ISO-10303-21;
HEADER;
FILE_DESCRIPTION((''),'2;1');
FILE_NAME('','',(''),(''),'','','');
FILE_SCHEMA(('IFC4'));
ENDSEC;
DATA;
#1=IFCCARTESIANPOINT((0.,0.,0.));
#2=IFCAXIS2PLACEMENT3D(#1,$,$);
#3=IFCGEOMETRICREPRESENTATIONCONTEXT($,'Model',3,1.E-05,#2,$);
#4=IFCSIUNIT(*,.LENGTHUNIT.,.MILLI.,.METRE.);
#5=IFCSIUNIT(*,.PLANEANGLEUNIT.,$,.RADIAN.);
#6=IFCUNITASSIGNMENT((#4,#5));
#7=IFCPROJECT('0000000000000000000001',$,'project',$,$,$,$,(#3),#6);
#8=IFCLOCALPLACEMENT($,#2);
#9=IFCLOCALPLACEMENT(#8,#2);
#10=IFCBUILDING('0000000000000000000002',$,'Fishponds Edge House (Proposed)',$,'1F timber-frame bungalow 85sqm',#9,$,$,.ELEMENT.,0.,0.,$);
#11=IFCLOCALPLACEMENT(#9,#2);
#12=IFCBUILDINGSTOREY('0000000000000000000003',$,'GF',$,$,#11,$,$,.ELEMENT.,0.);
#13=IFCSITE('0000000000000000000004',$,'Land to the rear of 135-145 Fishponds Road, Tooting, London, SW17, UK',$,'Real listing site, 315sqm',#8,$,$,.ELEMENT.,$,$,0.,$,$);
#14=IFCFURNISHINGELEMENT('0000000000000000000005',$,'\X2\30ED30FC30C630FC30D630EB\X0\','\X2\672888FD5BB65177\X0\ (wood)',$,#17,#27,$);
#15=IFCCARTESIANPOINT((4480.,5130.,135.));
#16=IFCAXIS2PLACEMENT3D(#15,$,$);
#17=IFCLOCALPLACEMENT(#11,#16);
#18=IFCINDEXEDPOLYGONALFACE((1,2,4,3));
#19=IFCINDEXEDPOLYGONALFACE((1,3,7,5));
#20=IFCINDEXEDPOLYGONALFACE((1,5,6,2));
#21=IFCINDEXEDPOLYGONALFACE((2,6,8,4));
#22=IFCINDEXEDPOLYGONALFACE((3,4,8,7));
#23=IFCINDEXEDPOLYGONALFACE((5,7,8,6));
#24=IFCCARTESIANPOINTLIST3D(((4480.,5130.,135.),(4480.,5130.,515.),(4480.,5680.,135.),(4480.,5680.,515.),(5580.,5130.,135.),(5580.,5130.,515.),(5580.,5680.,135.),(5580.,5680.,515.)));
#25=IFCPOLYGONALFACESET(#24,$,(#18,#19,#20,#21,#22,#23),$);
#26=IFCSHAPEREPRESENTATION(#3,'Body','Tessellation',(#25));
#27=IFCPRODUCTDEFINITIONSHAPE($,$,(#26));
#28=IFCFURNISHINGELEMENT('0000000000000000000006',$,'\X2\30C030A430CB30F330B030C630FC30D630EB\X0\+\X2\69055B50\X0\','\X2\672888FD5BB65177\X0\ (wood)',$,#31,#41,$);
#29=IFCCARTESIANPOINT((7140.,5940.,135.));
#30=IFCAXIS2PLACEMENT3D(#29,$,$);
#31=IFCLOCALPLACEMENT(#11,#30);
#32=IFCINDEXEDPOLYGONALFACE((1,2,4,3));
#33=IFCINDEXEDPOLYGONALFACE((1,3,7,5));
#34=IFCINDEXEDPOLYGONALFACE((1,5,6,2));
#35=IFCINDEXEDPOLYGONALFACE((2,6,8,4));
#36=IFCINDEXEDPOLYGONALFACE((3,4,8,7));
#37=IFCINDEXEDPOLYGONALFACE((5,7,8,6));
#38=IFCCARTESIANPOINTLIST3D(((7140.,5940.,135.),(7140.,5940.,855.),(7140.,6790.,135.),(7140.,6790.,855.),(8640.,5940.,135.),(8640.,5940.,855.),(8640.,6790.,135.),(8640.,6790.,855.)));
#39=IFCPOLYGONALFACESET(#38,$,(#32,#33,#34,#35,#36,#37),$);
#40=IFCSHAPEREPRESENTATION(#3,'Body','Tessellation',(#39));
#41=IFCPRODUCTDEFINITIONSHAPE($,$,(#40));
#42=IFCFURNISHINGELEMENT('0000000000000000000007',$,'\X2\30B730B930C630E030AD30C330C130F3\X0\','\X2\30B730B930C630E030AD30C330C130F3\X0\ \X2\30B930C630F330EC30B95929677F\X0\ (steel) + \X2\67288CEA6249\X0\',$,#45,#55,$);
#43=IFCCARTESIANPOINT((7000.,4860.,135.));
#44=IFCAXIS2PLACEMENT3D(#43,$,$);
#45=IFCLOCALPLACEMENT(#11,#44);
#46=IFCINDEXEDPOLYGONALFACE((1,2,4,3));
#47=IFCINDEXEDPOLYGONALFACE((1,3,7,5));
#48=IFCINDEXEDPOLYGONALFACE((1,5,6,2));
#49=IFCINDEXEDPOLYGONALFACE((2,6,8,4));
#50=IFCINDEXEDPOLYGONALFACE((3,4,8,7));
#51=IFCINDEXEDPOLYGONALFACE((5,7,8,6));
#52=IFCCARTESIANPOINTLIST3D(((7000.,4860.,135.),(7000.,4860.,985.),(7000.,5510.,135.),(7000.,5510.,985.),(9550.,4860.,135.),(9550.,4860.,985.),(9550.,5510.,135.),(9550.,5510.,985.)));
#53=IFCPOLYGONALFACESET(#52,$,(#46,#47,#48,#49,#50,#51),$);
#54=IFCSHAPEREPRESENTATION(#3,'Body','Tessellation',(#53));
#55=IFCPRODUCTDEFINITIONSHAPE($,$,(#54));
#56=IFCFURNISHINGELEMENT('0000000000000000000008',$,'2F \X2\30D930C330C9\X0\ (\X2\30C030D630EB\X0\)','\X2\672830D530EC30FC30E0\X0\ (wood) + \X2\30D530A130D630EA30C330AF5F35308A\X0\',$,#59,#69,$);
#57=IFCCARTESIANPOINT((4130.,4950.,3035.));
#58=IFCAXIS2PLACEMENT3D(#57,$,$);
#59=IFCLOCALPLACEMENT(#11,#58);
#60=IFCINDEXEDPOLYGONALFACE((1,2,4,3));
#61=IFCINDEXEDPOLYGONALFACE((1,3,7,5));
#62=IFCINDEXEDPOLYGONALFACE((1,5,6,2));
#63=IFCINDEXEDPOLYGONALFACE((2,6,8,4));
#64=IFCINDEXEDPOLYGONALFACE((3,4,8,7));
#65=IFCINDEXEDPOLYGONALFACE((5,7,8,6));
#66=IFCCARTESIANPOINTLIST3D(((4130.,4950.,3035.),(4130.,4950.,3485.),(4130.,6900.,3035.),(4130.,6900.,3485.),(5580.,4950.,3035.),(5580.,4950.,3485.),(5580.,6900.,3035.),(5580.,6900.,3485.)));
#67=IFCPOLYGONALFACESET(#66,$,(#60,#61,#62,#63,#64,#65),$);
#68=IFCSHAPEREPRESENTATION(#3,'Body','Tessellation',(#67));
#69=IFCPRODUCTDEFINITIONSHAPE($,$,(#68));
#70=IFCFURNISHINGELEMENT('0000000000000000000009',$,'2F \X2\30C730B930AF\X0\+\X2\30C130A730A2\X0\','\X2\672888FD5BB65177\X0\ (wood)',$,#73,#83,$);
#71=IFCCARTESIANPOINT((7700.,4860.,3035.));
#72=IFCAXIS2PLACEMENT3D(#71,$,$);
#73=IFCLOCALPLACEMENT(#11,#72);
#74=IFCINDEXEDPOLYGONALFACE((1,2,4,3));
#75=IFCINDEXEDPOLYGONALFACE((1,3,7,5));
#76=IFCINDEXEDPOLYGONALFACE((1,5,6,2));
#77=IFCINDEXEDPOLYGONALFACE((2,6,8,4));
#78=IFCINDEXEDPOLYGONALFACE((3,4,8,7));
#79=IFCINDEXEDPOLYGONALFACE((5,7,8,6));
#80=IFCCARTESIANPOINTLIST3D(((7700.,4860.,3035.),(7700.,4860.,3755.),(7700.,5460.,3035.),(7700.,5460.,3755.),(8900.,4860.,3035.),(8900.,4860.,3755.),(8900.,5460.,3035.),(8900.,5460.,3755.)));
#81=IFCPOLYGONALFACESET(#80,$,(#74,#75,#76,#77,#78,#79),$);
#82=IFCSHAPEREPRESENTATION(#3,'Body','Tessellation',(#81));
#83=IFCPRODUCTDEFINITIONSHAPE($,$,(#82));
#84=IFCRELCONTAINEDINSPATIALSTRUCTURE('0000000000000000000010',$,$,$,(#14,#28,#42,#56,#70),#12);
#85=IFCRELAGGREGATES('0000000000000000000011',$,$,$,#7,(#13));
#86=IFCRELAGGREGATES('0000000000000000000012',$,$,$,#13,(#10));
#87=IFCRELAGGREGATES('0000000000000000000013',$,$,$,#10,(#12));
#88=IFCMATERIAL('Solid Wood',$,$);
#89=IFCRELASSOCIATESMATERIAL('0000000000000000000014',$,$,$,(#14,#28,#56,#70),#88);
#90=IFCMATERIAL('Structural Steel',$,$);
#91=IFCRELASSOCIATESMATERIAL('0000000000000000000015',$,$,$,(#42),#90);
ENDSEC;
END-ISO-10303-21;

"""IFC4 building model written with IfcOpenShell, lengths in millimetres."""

from ifc_helpers import new_model, si_unit, frame, frame_2d, origin, place, context, project, spatial, rectangle, extrude, material, element, save


model = new_model("IFC4")

# Units and contexts
model_context = context("Model", 3, precision=1e-05, world=origin())
ifc_project = project(units=[si_unit("LENGTHUNIT", "METRE", prefix="MILLI"), si_unit("PLANEANGLEUNIT", "RADIAN")], contexts=[model_context])

# Site, building, storey
site_placement = place(None, origin())
site = spatial("IfcSite", under=ifc_project, at=site_placement, Name="Land to the rear of 135-145 Fishponds Road, Tooting, London, SW17, UK", ObjectType="Real listing site, 315sqm", CompositionType="ELEMENT", RefElevation=0.0)
building_placement = place(site_placement, origin())
building = spatial("IfcBuilding", under=site, at=building_placement, Name="Fishponds Edge House (Proposed)", ObjectType="1F timber-frame bungalow 85sqm", CompositionType="ELEMENT", ElevationOfRefHeight=0.0, ElevationOfTerrain=0.0)
storey_placement = place(building_placement, origin())
storey = spatial("IfcBuildingStorey", under=building, at=storey_placement, Name="GF", CompositionType="ELEMENT", Elevation=0.0)

# Shared definitions
ifc_material_1 = material(Name="Solid Wood")

# Shared definitions
ifc_material_2 = material(Name="Structural Steel")

# Furnishing elements
furnishing_1_placement = place(storey_placement, frame((4480.0, 5130.0, 135.0)))
element("IfcFurnishingElement", 1, at=furnishing_1_placement, inside=storey, material=ifc_material_1, Name="ローテーブル", Description="木製家具 (wood)", context=model_context, shape_type="SweptSolid", body=[
    extrude(rectangle(XDim=1100.0, YDim=550.0, at=frame_2d((550.0, 275.0))), frame((4480.0, 5130.0, 135.0)), (0.0, 0.0, 1.0), 380.0),
])
furnishing_2_placement = place(storey_placement, frame((7140.0, 5940.0, 135.0)))
element("IfcFurnishingElement", 2, at=furnishing_2_placement, inside=storey, material=ifc_material_1, Name="ダイニングテーブル+椅子", Description="木製家具 (wood)", context=model_context, shape_type="SweptSolid", body=[
    extrude(rectangle(XDim=1500.0, YDim=850.0, at=frame_2d((750.0, 425.0))), frame((7140.0, 5940.0, 135.0)), (0.0, 0.0, 1.0), 720.0),
])
furnishing_3_placement = place(storey_placement, frame((7000.0, 4860.0, 135.0)))
element("IfcFurnishingElement", 3, at=furnishing_3_placement, inside=storey, material=ifc_material_2, Name="システムキッチン", Description="システムキッチン ステンレス天板 (steel) + 木質扉", context=model_context, shape_type="SweptSolid", body=[
    extrude(rectangle(XDim=2550.0, YDim=650.0, at=frame_2d((1275.0, 325.0))), frame((7000.0, 4860.0, 135.0)), (0.0, 0.0, 1.0), 850.0),
])
furnishing_4_placement = place(storey_placement, frame((4130.0, 4950.0, 3035.0)))
element("IfcFurnishingElement", 4, at=furnishing_4_placement, inside=storey, material=ifc_material_1, Name="2F ベッド (ダブル)", Description="木フレーム (wood) + ファブリック張り", context=model_context, shape_type="SweptSolid", body=[
    extrude(rectangle(XDim=1450.0, YDim=1950.0, at=frame_2d((725.0, 975.0))), frame((4130.0, 4950.0, 3035.0)), (0.0, 0.0, 1.0), 450.0),
])
furnishing_5_placement = place(storey_placement, frame((7700.0, 4860.0, 3035.0)))
element("IfcFurnishingElement", 5, at=furnishing_5_placement, inside=storey, material=ifc_material_1, Name="2F デスク+チェア", Description="木製家具 (wood)", context=model_context, shape_type="SweptSolid", body=[
    extrude(rectangle(XDim=1200.0, YDim=600.0, at=frame_2d((600.0, 300.0))), frame((7700.0, 4860.0, 3035.0)), (0.0, 0.0, 1.0), 720.0),
])

save(model, "model.ifc")
